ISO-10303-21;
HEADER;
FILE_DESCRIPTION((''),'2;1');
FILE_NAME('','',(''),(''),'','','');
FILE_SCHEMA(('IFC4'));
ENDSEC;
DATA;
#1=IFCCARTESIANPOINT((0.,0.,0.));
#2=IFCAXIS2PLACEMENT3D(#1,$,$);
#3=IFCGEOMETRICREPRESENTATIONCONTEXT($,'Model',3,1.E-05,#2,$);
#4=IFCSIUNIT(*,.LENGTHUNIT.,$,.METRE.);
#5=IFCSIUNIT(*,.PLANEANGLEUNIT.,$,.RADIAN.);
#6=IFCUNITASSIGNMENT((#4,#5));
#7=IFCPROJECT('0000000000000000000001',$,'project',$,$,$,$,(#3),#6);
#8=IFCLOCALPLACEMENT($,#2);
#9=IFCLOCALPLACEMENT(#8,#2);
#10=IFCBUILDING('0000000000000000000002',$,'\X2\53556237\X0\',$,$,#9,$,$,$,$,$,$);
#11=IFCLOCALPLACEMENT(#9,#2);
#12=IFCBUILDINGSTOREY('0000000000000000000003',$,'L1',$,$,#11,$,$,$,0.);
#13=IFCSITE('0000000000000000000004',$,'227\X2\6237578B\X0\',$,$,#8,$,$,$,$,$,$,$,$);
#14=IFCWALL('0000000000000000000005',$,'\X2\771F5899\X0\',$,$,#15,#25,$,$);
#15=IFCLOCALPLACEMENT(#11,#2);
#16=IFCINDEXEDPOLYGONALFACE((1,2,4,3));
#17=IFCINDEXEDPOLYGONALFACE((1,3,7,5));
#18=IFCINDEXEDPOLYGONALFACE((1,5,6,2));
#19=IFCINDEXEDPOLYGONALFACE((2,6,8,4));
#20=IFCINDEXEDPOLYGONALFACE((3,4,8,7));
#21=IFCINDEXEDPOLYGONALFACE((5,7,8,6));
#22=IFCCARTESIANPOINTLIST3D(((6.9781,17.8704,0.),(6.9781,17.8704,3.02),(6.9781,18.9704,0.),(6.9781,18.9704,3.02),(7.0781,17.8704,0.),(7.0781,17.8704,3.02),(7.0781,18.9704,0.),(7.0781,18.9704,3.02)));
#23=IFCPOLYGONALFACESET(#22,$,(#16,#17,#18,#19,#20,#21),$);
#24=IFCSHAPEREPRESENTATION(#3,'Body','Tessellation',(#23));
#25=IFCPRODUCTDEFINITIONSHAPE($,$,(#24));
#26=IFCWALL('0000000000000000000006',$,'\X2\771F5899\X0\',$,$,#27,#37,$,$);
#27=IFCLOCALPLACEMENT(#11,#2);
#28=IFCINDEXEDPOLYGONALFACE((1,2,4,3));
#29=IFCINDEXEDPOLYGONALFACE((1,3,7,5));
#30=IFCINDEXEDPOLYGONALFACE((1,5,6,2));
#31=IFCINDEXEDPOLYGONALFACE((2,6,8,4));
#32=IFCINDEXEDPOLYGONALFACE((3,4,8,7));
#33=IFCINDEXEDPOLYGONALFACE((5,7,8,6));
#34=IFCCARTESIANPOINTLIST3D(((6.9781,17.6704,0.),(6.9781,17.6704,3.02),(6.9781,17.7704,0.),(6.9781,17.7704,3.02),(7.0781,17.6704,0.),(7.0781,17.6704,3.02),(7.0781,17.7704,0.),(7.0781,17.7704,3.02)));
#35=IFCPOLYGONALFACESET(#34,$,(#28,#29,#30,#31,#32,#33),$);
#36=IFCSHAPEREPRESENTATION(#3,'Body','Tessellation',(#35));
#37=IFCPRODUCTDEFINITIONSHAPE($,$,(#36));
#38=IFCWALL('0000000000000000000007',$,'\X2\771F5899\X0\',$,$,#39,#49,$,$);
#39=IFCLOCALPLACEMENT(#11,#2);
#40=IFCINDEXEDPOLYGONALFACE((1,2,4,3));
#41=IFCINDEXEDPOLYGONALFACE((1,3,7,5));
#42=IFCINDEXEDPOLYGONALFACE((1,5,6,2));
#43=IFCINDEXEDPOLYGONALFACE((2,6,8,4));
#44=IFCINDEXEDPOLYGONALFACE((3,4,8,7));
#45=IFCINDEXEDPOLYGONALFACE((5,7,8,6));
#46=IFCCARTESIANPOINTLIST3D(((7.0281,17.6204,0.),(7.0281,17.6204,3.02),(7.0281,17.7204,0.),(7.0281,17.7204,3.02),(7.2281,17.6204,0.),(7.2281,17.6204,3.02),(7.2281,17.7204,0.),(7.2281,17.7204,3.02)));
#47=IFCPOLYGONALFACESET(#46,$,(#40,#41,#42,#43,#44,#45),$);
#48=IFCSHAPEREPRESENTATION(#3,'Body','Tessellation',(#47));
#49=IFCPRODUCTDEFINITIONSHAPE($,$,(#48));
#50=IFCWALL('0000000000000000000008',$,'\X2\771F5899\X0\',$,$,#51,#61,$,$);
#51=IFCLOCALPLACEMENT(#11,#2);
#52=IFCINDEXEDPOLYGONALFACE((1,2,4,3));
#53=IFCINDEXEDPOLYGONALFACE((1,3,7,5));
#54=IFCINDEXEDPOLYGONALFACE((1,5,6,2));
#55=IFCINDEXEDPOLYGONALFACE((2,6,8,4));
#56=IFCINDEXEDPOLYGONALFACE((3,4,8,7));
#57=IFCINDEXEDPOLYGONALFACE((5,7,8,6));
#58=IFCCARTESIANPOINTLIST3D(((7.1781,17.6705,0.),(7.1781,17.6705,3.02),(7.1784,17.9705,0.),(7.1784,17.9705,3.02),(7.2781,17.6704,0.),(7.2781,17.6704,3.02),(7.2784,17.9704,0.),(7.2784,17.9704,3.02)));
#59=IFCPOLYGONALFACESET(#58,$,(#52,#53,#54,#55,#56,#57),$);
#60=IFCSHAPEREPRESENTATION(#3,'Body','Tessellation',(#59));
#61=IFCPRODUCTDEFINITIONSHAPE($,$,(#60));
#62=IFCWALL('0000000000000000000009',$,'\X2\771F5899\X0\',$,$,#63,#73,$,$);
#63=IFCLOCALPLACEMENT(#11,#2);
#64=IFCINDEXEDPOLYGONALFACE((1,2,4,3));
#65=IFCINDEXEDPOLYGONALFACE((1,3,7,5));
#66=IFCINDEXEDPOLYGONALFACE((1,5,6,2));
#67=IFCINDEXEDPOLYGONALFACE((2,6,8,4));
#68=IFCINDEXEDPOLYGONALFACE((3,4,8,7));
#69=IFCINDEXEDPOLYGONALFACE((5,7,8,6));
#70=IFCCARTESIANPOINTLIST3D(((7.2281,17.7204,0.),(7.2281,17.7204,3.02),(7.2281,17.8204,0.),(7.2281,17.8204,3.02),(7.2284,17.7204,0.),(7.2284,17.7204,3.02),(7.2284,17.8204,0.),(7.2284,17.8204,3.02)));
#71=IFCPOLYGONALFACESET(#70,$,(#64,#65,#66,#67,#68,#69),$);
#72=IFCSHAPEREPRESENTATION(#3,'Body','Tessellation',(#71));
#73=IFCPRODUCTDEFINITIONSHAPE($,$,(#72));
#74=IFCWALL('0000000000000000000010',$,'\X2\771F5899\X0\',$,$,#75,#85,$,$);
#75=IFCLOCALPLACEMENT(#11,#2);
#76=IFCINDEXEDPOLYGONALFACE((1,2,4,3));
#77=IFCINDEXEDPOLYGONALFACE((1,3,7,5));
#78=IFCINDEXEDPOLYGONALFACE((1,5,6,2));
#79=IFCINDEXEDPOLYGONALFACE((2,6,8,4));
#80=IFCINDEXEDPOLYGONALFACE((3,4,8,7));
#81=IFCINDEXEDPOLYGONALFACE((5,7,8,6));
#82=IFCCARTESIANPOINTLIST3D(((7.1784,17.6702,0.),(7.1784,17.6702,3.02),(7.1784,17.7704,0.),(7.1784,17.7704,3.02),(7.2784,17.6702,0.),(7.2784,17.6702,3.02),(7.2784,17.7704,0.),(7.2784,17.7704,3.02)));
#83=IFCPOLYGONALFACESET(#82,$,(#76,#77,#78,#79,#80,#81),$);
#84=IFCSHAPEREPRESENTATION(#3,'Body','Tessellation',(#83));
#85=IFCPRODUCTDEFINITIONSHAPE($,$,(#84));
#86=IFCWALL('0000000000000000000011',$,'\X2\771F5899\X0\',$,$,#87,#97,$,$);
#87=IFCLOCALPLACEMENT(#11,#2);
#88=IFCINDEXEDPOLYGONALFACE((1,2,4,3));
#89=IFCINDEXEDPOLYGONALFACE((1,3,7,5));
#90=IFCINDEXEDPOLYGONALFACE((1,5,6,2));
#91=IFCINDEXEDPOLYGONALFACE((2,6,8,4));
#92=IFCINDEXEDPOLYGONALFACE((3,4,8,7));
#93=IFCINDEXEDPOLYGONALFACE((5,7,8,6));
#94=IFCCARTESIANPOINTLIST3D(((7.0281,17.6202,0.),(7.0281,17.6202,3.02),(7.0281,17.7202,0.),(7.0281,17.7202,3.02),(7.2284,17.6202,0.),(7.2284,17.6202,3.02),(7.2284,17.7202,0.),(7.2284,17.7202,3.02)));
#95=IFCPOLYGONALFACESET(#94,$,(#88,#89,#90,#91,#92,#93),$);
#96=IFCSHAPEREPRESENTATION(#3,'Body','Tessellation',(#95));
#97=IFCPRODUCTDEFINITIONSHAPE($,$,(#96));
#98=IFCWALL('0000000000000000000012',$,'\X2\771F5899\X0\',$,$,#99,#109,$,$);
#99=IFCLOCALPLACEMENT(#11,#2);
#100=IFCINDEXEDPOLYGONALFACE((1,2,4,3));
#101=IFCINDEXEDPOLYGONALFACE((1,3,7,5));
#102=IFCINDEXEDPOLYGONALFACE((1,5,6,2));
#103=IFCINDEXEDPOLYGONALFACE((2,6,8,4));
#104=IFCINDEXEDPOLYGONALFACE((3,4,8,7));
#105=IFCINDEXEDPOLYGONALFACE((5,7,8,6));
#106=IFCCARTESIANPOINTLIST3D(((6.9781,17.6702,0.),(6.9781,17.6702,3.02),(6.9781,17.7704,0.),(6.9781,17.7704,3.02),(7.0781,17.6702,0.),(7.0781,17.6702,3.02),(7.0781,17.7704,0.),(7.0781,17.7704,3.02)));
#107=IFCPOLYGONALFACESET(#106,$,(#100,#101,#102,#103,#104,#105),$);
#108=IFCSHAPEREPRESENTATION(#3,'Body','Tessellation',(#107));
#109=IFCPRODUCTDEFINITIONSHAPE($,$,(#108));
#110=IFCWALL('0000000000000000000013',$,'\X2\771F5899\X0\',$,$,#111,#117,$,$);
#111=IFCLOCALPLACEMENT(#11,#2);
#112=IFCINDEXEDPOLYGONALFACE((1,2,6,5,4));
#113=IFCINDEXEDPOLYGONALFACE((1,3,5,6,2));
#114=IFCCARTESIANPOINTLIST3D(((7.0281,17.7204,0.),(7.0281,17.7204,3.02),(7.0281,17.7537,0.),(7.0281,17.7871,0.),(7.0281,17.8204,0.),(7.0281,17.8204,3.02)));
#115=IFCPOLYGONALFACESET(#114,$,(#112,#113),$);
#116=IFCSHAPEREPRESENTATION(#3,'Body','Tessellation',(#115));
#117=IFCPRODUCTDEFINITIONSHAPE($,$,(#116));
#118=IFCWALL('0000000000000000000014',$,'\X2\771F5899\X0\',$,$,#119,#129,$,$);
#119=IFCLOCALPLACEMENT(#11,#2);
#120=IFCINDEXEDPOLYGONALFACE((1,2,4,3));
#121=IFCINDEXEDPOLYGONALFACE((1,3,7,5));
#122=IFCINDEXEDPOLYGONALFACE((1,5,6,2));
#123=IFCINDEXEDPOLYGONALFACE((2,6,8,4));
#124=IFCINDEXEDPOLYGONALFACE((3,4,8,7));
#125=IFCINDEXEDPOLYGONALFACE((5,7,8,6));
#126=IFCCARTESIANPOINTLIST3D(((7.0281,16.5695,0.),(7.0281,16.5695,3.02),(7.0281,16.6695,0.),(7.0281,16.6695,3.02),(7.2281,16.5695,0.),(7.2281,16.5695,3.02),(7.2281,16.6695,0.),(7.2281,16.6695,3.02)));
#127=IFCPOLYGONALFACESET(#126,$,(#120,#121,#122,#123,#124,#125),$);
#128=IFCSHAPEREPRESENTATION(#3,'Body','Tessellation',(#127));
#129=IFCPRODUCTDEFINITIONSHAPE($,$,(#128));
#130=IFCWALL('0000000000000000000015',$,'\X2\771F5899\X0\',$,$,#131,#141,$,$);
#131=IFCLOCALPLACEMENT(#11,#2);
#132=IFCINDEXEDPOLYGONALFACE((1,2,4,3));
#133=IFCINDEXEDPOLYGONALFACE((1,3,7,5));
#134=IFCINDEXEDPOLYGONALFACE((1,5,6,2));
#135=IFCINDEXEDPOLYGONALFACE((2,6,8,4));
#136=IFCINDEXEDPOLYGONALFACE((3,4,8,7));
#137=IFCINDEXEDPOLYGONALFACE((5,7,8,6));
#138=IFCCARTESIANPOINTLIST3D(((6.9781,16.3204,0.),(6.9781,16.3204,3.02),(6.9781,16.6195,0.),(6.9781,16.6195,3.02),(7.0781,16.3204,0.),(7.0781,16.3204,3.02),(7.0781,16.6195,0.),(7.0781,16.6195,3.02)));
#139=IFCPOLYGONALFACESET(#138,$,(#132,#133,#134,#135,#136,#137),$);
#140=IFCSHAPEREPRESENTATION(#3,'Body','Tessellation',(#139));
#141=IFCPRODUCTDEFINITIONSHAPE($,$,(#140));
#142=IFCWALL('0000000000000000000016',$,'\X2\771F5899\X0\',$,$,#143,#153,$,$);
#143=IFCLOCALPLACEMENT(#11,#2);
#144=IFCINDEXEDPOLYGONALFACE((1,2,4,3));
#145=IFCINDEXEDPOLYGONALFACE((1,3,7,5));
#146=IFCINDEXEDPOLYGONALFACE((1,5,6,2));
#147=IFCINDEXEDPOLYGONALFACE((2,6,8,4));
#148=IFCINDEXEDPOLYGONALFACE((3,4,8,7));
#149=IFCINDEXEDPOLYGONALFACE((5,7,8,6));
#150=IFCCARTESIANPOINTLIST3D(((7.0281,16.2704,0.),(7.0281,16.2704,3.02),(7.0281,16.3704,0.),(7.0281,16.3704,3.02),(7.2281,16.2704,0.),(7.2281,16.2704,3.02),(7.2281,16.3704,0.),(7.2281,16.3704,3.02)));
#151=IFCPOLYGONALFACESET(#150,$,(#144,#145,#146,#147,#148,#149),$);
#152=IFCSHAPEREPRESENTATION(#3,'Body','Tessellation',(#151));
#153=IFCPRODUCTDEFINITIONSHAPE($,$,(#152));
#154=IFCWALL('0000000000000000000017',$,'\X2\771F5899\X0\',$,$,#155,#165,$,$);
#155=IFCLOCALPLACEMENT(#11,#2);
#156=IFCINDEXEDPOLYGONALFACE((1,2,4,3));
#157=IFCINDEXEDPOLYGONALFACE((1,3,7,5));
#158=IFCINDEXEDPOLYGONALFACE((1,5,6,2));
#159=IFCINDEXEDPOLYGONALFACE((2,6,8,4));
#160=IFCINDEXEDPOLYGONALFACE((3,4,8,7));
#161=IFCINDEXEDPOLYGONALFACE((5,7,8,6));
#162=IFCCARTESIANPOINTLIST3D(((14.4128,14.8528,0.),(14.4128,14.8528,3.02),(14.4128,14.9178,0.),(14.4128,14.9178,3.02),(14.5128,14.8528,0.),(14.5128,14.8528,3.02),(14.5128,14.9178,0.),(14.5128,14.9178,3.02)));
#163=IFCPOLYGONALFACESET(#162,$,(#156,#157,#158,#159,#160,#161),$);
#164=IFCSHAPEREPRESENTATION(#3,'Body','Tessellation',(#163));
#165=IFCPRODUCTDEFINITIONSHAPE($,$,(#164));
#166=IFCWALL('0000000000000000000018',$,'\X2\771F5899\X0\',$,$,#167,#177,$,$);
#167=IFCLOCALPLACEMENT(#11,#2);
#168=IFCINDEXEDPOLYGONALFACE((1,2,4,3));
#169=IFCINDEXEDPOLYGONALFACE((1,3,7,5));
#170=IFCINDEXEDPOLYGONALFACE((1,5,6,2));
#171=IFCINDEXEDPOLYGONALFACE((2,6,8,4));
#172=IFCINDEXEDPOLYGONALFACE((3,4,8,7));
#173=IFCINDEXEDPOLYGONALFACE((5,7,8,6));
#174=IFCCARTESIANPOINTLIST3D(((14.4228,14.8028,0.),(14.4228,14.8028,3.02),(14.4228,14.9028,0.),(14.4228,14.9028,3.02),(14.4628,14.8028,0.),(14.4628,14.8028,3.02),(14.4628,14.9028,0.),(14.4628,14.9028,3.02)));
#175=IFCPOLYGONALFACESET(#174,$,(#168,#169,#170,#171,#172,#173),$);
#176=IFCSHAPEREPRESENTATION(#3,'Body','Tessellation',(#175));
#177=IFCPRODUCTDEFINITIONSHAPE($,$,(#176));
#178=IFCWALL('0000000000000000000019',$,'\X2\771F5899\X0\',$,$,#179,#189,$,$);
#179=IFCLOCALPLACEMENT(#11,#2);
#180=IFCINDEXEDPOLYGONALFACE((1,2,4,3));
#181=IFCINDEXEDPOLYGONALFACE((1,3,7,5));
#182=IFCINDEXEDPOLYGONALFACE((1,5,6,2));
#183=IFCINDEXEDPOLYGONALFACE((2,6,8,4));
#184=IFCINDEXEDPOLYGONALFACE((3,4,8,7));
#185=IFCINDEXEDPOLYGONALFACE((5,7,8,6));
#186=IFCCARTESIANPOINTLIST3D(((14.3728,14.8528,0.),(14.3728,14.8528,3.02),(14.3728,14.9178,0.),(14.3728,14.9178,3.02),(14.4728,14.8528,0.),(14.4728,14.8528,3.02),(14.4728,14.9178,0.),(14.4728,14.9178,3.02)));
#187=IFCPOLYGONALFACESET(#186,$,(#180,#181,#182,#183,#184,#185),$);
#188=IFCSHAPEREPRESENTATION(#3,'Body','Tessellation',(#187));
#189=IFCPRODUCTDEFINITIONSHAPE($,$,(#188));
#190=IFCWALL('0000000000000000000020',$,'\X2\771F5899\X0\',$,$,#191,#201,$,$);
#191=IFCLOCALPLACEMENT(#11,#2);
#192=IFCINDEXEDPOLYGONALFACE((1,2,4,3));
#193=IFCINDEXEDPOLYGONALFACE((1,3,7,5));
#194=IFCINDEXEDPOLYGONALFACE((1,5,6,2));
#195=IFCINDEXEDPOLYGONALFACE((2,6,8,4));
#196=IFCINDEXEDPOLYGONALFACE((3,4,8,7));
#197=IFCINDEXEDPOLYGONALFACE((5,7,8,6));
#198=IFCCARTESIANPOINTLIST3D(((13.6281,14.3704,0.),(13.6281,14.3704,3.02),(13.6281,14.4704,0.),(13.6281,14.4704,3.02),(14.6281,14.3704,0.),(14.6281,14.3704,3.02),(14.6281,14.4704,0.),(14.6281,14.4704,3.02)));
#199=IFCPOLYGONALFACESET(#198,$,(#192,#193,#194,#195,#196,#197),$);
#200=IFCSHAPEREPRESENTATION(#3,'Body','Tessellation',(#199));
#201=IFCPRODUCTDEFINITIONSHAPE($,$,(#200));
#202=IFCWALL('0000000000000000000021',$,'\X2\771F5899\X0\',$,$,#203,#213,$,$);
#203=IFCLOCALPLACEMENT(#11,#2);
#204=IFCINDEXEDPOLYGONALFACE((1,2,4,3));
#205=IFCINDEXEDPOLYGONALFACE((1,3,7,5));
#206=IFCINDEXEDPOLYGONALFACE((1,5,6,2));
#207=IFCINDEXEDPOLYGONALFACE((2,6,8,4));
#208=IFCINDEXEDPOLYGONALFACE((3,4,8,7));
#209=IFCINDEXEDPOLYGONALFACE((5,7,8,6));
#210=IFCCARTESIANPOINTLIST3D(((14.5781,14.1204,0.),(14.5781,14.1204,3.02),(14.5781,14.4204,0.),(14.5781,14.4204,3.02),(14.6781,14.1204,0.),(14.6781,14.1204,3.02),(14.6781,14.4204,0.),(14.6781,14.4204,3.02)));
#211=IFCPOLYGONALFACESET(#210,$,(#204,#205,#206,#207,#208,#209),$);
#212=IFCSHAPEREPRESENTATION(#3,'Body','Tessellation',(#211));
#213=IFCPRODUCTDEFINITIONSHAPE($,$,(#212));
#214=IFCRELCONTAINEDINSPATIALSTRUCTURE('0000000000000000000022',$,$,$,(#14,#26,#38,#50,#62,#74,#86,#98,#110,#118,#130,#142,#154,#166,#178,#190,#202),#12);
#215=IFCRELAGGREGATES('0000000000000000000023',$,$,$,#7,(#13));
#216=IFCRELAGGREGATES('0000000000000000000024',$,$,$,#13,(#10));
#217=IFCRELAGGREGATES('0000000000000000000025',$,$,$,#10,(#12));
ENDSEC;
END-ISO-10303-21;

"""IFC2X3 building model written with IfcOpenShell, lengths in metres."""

from ifc_helpers import new_model, si_unit, origin, place, context, project, spatial, polyline, outline, extrude, element, save


model = new_model("IFC2X3")

# Units and contexts
model_context = context("Model", 3, precision=1e-05, world=origin())
ifc_project = project(units=[si_unit("LENGTHUNIT", "METRE"), si_unit("PLANEANGLEUNIT", "RADIAN")], contexts=[model_context])

# Site, building, storey
site_placement = place(None, origin())
site = spatial("IfcSite", under=ifc_project, at=site_placement, Name="227户型")
building_placement = place(site_placement, origin())
building = spatial("IfcBuilding", under=site, at=building_placement, Name="单户")
storey_placement = place(building_placement, origin())
storey = spatial("IfcBuildingStorey", under=building, at=storey_placement, Name="L1", Elevation=0.0)

# Walls
wall_1_placement = place(storey_placement, origin())
element("IfcWall", 1, at=wall_1_placement, inside=storey, Name="真墙", context=model_context, shape_type="SweptSolid", body=[
    extrude(outline(polyline([(7.0781, 18.9704), (7.0781, 17.8704), (6.9781, 17.8704), (6.9781, 18.9704), (7.0781, 18.9704)])), origin(), (0.0, 0.0, 1.0), 3.02),
])
wall_2_placement = place(storey_placement, origin())
element("IfcWall", 2, at=wall_2_placement, inside=storey, Name="真墙", context=model_context, shape_type="SweptSolid", body=[
    extrude(outline(polyline([(7.0781, 17.7704), (7.0781, 17.6704), (6.9781, 17.6704), (6.9781, 17.7704), (7.0781, 17.7704)])), origin(), (0.0, 0.0, 1.0), 3.02),
])
wall_3_placement = place(storey_placement, origin())
element("IfcWall", 3, at=wall_3_placement, inside=storey, Name="真墙", context=model_context, shape_type="SweptSolid", body=[
    extrude(outline(polyline([(7.0281, 17.7204), (7.2281, 17.7204), (7.2281, 17.6204), (7.0281, 17.6204), (7.0281, 17.7204)])), origin(), (0.0, 0.0, 1.0), 3.02),
])
wall_4_placement = place(storey_placement, origin())
element("IfcWall", 4, at=wall_4_placement, inside=storey, Name="真墙", context=model_context, shape_type="SweptSolid", body=[
    extrude(outline(polyline([(7.1781, 17.6705), (7.1784, 17.9705), (7.2784, 17.9704), (7.2781, 17.6704), (7.1781, 17.6705)])), origin(), (0.0, 0.0, 1.0), 3.02),
])
wall_5_placement = place(storey_placement, origin())
element("IfcWall", 5, at=wall_5_placement, inside=storey, Name="真墙", context=model_context, shape_type="SweptSolid", body=[
    extrude(outline(polyline([(7.2281, 17.8204), (7.2284, 17.8204), (7.2284, 17.7204), (7.2281, 17.7204), (7.2281, 17.8204)])), origin(), (0.0, 0.0, 1.0), 3.02),
])
wall_6_placement = place(storey_placement, origin())
element("IfcWall", 6, at=wall_6_placement, inside=storey, Name="真墙", context=model_context, shape_type="SweptSolid", body=[
    extrude(outline(polyline([(7.2784, 17.7704), (7.2784, 17.6702), (7.1784, 17.6702), (7.1784, 17.7704), (7.2784, 17.7704)])), origin(), (0.0, 0.0, 1.0), 3.02),
])
wall_7_placement = place(storey_placement, origin())
element("IfcWall", 7, at=wall_7_placement, inside=storey, Name="真墙", context=model_context, shape_type="SweptSolid", body=[
    extrude(outline(polyline([(7.2284, 17.6202), (7.0281, 17.6202), (7.0281, 17.7202), (7.2284, 17.7202), (7.2284, 17.6202)])), origin(), (0.0, 0.0, 1.0), 3.02),
])
wall_8_placement = place(storey_placement, origin())
element("IfcWall", 8, at=wall_8_placement, inside=storey, Name="真墙", context=model_context, shape_type="SweptSolid", body=[
    extrude(outline(polyline([(6.9781, 17.6702), (6.9781, 17.7704), (7.0781, 17.7704), (7.0781, 17.6702), (6.9781, 17.6702)])), origin(), (0.0, 0.0, 1.0), 3.02),
])
wall_9_placement = place(storey_placement, origin())
element("IfcWall", 9, at=wall_9_placement, inside=storey, Name="真墙", context=model_context, shape_type="SweptSolid", body=[
    extrude(outline(polyline([(7.0281, 17.8204), (7.0281, 17.8204), (7.0281, 17.7204), (7.0281, 17.7204), (7.0281, 17.8204)])), origin(), (0.0, 0.0, 1.0), 3.02),
])
wall_10_placement = place(storey_placement, origin())
element("IfcWall", 10, at=wall_10_placement, inside=storey, Name="真墙", context=model_context, shape_type="SweptSolid", body=[
    extrude(outline(polyline([(7.2281, 16.5695), (7.0281, 16.5695), (7.0281, 16.6695), (7.2281, 16.6695), (7.2281, 16.5695)])), origin(), (0.0, 0.0, 1.0), 3.02),
])
wall_11_placement = place(storey_placement, origin())
element("IfcWall", 11, at=wall_11_placement, inside=storey, Name="真墙", context=model_context, shape_type="SweptSolid", body=[
    extrude(outline(polyline([(7.0781, 16.6195), (7.0781, 16.3204), (6.9781, 16.3204), (6.9781, 16.6195), (7.0781, 16.6195)])), origin(), (0.0, 0.0, 1.0), 3.02),
])
wall_12_placement = place(storey_placement, origin())
element("IfcWall", 12, at=wall_12_placement, inside=storey, Name="真墙", context=model_context, shape_type="SweptSolid", body=[
    extrude(outline(polyline([(7.0281, 16.3704), (7.2281, 16.3704), (7.2281, 16.2704), (7.0281, 16.2704), (7.0281, 16.3704)])), origin(), (0.0, 0.0, 1.0), 3.02),
])
wall_13_placement = place(storey_placement, origin())
element("IfcWall", 13, at=wall_13_placement, inside=storey, Name="真墙", context=model_context, shape_type="SweptSolid", body=[
    extrude(outline(polyline([(14.5128, 14.9178), (14.5128, 14.8528), (14.4128, 14.8528), (14.4128, 14.9178), (14.5128, 14.9178)])), origin(), (0.0, 0.0, 1.0), 3.02),
])
wall_14_placement = place(storey_placement, origin())
element("IfcWall", 14, at=wall_14_placement, inside=storey, Name="真墙", context=model_context, shape_type="SweptSolid", body=[
    extrude(outline(polyline([(14.4628, 14.8028), (14.4228, 14.8028), (14.4228, 14.9028), (14.4628, 14.9028), (14.4628, 14.8028)])), origin(), (0.0, 0.0, 1.0), 3.02),
])
wall_15_placement = place(storey_placement, origin())
element("IfcWall", 15, at=wall_15_placement, inside=storey, Name="真墙", context=model_context, shape_type="SweptSolid", body=[
    extrude(outline(polyline([(14.3728, 14.8528), (14.3728, 14.9178), (14.4728, 14.9178), (14.4728, 14.8528), (14.3728, 14.8528)])), origin(), (0.0, 0.0, 1.0), 3.02),
])
wall_16_placement = place(storey_placement, origin())
element("IfcWall", 16, at=wall_16_placement, inside=storey, Name="真墙", context=model_context, shape_type="SweptSolid", body=[
    extrude(outline(polyline([(13.6281, 14.4704), (14.6281, 14.4704), (14.6281, 14.3704), (13.6281, 14.3704), (13.6281, 14.4704)])), origin(), (0.0, 0.0, 1.0), 3.02),
])
wall_17_placement = place(storey_placement, origin())
element("IfcWall", 17, at=wall_17_placement, inside=storey, Name="真墙", context=model_context, shape_type="SweptSolid", body=[
    extrude(outline(polyline([(14.6781, 14.4204), (14.6781, 14.1204), (14.5781, 14.1204), (14.5781, 14.4204), (14.6781, 14.4204)])), origin(), (0.0, 0.0, 1.0), 3.02),
])

save(model, "model.ifc")
